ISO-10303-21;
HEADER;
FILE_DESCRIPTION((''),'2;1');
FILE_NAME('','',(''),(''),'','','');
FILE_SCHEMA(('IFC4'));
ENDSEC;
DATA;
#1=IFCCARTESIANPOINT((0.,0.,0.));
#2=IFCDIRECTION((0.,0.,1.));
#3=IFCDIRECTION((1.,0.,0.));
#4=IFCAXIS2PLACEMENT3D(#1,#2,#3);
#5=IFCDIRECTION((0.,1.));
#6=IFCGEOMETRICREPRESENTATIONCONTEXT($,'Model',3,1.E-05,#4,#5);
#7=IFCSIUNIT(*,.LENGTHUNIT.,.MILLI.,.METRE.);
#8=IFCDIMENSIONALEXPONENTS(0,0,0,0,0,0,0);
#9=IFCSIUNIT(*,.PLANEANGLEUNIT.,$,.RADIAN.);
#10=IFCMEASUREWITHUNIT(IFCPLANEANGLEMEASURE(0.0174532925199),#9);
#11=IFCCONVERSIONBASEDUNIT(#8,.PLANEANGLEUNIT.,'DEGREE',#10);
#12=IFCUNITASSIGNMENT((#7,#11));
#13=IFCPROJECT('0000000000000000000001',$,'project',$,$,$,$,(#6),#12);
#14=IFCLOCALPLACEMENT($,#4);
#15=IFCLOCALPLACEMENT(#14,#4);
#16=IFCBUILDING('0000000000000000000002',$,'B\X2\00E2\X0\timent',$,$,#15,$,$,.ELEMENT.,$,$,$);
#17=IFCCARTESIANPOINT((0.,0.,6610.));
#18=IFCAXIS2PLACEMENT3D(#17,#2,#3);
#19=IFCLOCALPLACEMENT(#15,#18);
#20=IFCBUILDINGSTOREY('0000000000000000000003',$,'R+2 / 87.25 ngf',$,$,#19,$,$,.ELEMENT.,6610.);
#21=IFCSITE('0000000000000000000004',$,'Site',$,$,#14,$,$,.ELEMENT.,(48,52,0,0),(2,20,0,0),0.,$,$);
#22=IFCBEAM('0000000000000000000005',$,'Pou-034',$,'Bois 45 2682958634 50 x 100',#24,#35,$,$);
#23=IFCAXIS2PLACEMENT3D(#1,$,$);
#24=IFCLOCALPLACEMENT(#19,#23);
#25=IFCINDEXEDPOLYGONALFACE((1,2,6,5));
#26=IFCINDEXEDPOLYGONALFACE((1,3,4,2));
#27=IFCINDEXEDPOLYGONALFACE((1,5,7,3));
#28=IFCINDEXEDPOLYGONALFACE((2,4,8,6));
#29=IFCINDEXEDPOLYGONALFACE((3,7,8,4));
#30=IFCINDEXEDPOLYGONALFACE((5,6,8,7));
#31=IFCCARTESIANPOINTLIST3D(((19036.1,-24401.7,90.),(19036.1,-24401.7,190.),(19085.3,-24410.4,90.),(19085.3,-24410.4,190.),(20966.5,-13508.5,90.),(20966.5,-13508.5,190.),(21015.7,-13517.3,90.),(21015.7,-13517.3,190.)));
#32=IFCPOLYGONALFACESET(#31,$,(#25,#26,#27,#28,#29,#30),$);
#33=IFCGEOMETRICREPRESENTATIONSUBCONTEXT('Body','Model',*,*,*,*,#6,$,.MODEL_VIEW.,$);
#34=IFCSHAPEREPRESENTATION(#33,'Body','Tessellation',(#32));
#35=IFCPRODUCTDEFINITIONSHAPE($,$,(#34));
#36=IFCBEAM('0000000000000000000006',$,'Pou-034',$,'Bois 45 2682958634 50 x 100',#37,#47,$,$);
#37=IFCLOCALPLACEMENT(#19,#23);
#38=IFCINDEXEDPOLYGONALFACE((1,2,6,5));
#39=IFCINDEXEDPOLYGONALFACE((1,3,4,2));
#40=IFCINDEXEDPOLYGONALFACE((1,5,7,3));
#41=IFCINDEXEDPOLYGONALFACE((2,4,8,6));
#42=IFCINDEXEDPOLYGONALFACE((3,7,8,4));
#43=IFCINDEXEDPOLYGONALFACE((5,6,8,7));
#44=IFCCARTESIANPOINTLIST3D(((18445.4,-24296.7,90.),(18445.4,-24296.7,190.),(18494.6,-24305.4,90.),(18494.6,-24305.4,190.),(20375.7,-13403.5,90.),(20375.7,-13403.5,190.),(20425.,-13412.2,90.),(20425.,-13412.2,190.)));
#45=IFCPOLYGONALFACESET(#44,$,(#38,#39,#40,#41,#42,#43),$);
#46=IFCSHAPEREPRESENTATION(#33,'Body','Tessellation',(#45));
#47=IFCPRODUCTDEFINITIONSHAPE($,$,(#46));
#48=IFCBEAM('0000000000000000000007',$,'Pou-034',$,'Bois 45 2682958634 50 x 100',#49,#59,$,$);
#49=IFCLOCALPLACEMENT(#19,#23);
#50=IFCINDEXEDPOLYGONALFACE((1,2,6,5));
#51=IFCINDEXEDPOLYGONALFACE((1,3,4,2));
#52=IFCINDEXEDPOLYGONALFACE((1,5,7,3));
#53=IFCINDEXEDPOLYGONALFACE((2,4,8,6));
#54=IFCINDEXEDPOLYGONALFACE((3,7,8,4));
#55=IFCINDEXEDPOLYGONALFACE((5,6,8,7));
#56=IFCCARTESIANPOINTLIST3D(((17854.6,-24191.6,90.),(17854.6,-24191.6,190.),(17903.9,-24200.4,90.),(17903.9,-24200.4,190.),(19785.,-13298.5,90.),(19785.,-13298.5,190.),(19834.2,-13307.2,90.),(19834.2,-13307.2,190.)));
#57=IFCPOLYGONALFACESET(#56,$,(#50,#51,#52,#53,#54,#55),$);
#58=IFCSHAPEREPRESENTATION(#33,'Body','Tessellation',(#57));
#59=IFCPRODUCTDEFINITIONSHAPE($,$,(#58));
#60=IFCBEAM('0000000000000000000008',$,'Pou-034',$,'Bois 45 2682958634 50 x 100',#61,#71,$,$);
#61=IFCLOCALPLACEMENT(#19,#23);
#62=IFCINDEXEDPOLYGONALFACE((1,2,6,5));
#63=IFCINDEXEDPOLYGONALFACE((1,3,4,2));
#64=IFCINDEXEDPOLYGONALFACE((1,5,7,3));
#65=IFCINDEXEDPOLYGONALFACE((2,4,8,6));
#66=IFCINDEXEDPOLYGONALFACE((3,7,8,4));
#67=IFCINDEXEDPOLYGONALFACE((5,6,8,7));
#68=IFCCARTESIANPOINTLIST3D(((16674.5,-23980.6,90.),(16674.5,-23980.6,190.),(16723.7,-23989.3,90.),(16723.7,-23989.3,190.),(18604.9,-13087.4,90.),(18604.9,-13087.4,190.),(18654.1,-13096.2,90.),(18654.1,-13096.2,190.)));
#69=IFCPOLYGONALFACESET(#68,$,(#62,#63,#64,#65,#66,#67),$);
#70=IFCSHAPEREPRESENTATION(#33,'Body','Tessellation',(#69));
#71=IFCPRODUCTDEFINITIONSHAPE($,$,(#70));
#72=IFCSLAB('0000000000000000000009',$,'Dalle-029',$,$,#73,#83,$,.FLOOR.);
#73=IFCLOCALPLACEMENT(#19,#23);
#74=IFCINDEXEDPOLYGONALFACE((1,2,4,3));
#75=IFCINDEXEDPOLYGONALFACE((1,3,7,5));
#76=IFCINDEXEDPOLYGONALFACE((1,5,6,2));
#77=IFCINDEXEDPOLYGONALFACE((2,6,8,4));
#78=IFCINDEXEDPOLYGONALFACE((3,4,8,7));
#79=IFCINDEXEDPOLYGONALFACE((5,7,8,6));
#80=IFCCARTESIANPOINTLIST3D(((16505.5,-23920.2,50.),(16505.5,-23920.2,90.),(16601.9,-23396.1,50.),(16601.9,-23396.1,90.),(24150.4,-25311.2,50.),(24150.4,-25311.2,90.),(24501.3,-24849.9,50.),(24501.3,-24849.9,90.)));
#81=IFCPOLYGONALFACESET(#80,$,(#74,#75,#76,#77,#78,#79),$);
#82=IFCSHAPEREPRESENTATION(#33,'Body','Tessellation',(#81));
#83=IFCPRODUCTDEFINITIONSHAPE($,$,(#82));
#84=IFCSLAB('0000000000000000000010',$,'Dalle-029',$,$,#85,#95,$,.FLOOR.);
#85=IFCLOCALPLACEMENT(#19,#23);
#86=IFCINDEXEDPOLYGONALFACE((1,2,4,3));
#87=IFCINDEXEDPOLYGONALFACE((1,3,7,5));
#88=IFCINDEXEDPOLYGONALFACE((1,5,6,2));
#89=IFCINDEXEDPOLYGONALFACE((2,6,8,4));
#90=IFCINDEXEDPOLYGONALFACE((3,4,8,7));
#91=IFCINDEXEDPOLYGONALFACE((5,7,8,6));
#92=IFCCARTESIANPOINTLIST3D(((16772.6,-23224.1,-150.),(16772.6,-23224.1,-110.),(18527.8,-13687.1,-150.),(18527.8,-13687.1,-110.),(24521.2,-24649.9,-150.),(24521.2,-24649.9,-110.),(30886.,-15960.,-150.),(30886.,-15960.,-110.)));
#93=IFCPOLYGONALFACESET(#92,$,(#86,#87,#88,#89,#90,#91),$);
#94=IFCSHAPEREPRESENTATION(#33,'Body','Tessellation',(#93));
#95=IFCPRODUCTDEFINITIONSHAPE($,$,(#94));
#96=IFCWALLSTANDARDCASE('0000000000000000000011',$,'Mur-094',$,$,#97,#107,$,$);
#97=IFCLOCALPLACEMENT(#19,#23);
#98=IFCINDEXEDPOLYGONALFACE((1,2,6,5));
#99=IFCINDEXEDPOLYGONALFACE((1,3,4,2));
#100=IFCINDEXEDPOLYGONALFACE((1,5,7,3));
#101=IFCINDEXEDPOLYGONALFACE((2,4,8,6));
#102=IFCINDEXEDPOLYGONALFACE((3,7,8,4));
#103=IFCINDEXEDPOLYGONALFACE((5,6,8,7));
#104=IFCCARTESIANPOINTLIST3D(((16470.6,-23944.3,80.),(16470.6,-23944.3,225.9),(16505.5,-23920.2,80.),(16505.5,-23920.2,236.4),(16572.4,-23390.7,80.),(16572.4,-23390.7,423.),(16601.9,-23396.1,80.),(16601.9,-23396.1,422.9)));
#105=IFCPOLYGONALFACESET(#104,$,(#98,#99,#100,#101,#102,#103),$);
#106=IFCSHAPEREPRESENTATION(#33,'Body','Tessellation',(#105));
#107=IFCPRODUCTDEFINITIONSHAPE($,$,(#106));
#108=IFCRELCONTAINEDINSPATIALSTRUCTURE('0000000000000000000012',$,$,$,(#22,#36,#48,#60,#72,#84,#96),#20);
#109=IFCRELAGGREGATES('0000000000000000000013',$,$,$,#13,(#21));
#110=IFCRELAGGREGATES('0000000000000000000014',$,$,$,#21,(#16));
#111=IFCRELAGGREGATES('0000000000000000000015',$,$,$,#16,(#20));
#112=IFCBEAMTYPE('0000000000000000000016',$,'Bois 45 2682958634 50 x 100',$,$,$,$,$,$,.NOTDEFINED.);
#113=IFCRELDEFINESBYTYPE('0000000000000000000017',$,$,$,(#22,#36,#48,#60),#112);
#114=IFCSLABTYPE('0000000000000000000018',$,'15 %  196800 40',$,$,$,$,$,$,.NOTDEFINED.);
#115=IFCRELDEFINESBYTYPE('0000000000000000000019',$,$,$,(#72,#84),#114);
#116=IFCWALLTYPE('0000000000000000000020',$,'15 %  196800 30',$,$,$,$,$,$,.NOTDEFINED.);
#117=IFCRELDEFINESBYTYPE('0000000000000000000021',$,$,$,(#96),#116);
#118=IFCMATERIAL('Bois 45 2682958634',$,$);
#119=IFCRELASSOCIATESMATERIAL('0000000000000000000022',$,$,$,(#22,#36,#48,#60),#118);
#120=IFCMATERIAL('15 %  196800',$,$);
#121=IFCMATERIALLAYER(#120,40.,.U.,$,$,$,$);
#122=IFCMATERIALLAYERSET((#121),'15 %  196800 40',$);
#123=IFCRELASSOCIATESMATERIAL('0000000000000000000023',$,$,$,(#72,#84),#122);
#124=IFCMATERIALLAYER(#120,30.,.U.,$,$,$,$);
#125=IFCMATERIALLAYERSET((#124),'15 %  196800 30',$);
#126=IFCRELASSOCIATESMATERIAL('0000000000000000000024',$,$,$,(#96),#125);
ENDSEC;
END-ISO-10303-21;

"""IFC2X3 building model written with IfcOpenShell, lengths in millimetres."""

from ifc_helpers import new_model, entity, si_unit, converted_unit, direction, frame, frame_2d, origin_with_axes, place, context, subcontext, project, spatial, polyline, rectangle, outline, extrude, clip, halfspace, material, layer, layer_set, layer_usage, type_object, element, save


model = new_model("IFC2X3")

# Units and contexts
model_context = context("Model", 3, precision=1e-05, world=origin_with_axes(), true_north=direction((0.0, 1.0)))
body_context = subcontext(model_context, "Body", "Model", "MODEL_VIEW")
ifc_project = project(units=[si_unit("LENGTHUNIT", "METRE", prefix="MILLI"), converted_unit("PLANEANGLEUNIT", "DEGREE", entity("IfcPlaneAngleMeasure", 0.0174532925199), si_unit("PLANEANGLEUNIT", "RADIAN"), dimensions=[0, 0, 0, 0, 0, 0, 0])], contexts=[model_context])

# Site, building, storey
site_placement = place(None, origin_with_axes())
site = spatial("IfcSite", under=ifc_project, at=site_placement, Name="Site", CompositionType="ELEMENT", RefLatitude=(48, 52, 0, 0), RefLongitude=(2, 20, 0, 0), RefElevation=0.0)
building_placement = place(site_placement, origin_with_axes())
building = spatial("IfcBuilding", under=site, at=building_placement, Name="Bâtiment", CompositionType="ELEMENT")
storey_placement = place(building_placement, frame((0.0, 0.0, 6610.0), z_axis=(0.0, 0.0, 1.0), x_axis=(1.0, 0.0, 0.0)))
storey = spatial("IfcBuildingStorey", under=building, at=storey_placement, Name="R+2 / 87.25 ngf", CompositionType="ELEMENT", Elevation=6610.0)

# Beams
ifc_material_1 = material(Name="Bois 45 2682958634")
beam_type = type_object("IfcBeamType", Name="Bois 45 2682958634 50 x 100", PredefinedType="NOTDEFINED")
for number, where, z_axis, x_axis, name in (
    (1, (19060.7, -24406.1, 190.0), (0.0, 0.0, 1.0), (0.984659, -0.174492, 0.0), "Pou-034"),
    (2, (18470.0, -24301.0, 190.0), (0.0, 0.0, 1.0), (0.984659, -0.174492, 0.0), "Pou-034"),
    (3, (17879.2, -24196.0, 190.0), (0.0, 0.0, 1.0), (0.984659, -0.174492, 0.0), "Pou-034"),
    (4, (16699.1, -23985.0, 190.0), (0.0, 0.0, 1.0), (0.984659, -0.174492, 0.0), "Pou-034"),
):
    element("IfcBeam", number, at=place(storey_placement, frame(where, z_axis=z_axis, x_axis=x_axis)), inside=storey, type_object=beam_type, material=ifc_material_1, Name=name, ObjectType="Bois 45 2682958634 50 x 100", context=body_context, shape_type="SweptSolid", body=[
        extrude(rectangle(XDim=100.0, YDim=50.0, at=frame_2d((-50.0, 0.0), x_axis=(1.0, 0.0))), frame((0.0, 0.0, 0.0), z_axis=(0.0, 1.0, 0.0), x_axis=(0.0, 0.0, 1.0)), (0.0, 0.0, 1.0), 11062.9),
    ])

# Slabs
ifc_material_2 = material(Name="15 %  196800")
ifc_layer_1 = layer(ifc_material_2, 40.0, ventilated="UNKNOWN")
ifc_layer_set_1 = layer_set([ifc_layer_1], Name="15 %  196800 40")
ifc_layer_usage_1 = layer_usage(ifc_layer_set_1, "AXIS3", "NEGATIVE", 40.0)
slab_type = type_object("IfcSlabType", Name="15 %  196800 40", PredefinedType="NOTDEFINED")
slab_1_placement = place(storey_placement, frame((16505.5, -23920.2, 90.0), z_axis=(0.0, 0.0, 1.0), x_axis=(1.0, 0.0, 0.0)))
element("IfcSlab", 5, at=slab_1_placement, inside=storey, type_object=slab_type, material=ifc_layer_usage_1, Name="Dalle-029", PredefinedType="FLOOR", context=body_context, shape_type="SweptSolid", body=[
    extrude(outline(polyline([(0.0, 0.0), (7644.9, -1391.1), (7995.8, -929.7), (96.4, 524.1), (0.0, 0.0)])), frame((0.0, 0.0, -40.0), z_axis=(0.0, 0.0, 1.0), x_axis=(1.0, 0.0, 0.0)), (0.0, 0.0, 1.0), 40.0),
])
ifc_layer_usage_2 = layer_usage(ifc_layer_set_1, "AXIS3", "NEGATIVE", 40.0)
slab_2_placement = place(storey_placement, frame((16772.6, -23224.1, -110.0), z_axis=(0.0, 0.0, 1.0), x_axis=(1.0, 0.0, 0.0)))
element("IfcSlab", 6, at=slab_2_placement, inside=storey, type_object=slab_type, material=ifc_layer_usage_2, Name="Dalle-029", PredefinedType="FLOOR", context=body_context, shape_type="SweptSolid", body=[
    extrude(outline(polyline([(0.0, 0.0), (7748.6, -1425.8), (14113.4, 7264.1), (1755.2, 9536.9), (0.0, 0.0)])), frame((0.0, 0.0, -40.0), z_axis=(0.0, 0.0, 1.0), x_axis=(1.0, 0.0, 0.0)), (0.0, 0.0, 1.0), 40.0),
])

# Wall
ifc_layer_2 = layer(ifc_material_2, 30.0, ventilated="UNKNOWN")
ifc_layer_set_2 = layer_set([ifc_layer_2], Name="15 %  196800 30")
ifc_layer_usage_3 = layer_usage(ifc_layer_set_2, "AXIS2", "NEGATIVE", 30.0)
wall_type = type_object("IfcWallType", Name="15 %  196800 30", PredefinedType="NOTDEFINED")
wall_placement = place(storey_placement, frame((16505.5, -23920.2, 80.0), z_axis=(0.0, 0.0, 1.0), x_axis=(0.180998, 0.983484, 0.0)))
element("IfcWallStandardCase", 7, at=wall_placement, inside=storey, type_object=wall_type, material=ifc_layer_usage_3, Name="Mur-094", context=body_context, shape_type="Clipping", body=[
    clip(extrude(outline(polyline([(0.0, 0.0), (532.9, 0.0), (532.9, 30.0), (-30.1, 30.0), (0.0, 0.0)])), origin_with_axes(), (0.0, 0.0, 1.0), 590.0), halfspace(frame((-48.8, -0.3, 139.3), z_axis=(0.330345, 0.001925, -0.943858), x_axis=(0.0, 0.999998, 0.002039)), True)),
])

save(model, "model.ifc")
